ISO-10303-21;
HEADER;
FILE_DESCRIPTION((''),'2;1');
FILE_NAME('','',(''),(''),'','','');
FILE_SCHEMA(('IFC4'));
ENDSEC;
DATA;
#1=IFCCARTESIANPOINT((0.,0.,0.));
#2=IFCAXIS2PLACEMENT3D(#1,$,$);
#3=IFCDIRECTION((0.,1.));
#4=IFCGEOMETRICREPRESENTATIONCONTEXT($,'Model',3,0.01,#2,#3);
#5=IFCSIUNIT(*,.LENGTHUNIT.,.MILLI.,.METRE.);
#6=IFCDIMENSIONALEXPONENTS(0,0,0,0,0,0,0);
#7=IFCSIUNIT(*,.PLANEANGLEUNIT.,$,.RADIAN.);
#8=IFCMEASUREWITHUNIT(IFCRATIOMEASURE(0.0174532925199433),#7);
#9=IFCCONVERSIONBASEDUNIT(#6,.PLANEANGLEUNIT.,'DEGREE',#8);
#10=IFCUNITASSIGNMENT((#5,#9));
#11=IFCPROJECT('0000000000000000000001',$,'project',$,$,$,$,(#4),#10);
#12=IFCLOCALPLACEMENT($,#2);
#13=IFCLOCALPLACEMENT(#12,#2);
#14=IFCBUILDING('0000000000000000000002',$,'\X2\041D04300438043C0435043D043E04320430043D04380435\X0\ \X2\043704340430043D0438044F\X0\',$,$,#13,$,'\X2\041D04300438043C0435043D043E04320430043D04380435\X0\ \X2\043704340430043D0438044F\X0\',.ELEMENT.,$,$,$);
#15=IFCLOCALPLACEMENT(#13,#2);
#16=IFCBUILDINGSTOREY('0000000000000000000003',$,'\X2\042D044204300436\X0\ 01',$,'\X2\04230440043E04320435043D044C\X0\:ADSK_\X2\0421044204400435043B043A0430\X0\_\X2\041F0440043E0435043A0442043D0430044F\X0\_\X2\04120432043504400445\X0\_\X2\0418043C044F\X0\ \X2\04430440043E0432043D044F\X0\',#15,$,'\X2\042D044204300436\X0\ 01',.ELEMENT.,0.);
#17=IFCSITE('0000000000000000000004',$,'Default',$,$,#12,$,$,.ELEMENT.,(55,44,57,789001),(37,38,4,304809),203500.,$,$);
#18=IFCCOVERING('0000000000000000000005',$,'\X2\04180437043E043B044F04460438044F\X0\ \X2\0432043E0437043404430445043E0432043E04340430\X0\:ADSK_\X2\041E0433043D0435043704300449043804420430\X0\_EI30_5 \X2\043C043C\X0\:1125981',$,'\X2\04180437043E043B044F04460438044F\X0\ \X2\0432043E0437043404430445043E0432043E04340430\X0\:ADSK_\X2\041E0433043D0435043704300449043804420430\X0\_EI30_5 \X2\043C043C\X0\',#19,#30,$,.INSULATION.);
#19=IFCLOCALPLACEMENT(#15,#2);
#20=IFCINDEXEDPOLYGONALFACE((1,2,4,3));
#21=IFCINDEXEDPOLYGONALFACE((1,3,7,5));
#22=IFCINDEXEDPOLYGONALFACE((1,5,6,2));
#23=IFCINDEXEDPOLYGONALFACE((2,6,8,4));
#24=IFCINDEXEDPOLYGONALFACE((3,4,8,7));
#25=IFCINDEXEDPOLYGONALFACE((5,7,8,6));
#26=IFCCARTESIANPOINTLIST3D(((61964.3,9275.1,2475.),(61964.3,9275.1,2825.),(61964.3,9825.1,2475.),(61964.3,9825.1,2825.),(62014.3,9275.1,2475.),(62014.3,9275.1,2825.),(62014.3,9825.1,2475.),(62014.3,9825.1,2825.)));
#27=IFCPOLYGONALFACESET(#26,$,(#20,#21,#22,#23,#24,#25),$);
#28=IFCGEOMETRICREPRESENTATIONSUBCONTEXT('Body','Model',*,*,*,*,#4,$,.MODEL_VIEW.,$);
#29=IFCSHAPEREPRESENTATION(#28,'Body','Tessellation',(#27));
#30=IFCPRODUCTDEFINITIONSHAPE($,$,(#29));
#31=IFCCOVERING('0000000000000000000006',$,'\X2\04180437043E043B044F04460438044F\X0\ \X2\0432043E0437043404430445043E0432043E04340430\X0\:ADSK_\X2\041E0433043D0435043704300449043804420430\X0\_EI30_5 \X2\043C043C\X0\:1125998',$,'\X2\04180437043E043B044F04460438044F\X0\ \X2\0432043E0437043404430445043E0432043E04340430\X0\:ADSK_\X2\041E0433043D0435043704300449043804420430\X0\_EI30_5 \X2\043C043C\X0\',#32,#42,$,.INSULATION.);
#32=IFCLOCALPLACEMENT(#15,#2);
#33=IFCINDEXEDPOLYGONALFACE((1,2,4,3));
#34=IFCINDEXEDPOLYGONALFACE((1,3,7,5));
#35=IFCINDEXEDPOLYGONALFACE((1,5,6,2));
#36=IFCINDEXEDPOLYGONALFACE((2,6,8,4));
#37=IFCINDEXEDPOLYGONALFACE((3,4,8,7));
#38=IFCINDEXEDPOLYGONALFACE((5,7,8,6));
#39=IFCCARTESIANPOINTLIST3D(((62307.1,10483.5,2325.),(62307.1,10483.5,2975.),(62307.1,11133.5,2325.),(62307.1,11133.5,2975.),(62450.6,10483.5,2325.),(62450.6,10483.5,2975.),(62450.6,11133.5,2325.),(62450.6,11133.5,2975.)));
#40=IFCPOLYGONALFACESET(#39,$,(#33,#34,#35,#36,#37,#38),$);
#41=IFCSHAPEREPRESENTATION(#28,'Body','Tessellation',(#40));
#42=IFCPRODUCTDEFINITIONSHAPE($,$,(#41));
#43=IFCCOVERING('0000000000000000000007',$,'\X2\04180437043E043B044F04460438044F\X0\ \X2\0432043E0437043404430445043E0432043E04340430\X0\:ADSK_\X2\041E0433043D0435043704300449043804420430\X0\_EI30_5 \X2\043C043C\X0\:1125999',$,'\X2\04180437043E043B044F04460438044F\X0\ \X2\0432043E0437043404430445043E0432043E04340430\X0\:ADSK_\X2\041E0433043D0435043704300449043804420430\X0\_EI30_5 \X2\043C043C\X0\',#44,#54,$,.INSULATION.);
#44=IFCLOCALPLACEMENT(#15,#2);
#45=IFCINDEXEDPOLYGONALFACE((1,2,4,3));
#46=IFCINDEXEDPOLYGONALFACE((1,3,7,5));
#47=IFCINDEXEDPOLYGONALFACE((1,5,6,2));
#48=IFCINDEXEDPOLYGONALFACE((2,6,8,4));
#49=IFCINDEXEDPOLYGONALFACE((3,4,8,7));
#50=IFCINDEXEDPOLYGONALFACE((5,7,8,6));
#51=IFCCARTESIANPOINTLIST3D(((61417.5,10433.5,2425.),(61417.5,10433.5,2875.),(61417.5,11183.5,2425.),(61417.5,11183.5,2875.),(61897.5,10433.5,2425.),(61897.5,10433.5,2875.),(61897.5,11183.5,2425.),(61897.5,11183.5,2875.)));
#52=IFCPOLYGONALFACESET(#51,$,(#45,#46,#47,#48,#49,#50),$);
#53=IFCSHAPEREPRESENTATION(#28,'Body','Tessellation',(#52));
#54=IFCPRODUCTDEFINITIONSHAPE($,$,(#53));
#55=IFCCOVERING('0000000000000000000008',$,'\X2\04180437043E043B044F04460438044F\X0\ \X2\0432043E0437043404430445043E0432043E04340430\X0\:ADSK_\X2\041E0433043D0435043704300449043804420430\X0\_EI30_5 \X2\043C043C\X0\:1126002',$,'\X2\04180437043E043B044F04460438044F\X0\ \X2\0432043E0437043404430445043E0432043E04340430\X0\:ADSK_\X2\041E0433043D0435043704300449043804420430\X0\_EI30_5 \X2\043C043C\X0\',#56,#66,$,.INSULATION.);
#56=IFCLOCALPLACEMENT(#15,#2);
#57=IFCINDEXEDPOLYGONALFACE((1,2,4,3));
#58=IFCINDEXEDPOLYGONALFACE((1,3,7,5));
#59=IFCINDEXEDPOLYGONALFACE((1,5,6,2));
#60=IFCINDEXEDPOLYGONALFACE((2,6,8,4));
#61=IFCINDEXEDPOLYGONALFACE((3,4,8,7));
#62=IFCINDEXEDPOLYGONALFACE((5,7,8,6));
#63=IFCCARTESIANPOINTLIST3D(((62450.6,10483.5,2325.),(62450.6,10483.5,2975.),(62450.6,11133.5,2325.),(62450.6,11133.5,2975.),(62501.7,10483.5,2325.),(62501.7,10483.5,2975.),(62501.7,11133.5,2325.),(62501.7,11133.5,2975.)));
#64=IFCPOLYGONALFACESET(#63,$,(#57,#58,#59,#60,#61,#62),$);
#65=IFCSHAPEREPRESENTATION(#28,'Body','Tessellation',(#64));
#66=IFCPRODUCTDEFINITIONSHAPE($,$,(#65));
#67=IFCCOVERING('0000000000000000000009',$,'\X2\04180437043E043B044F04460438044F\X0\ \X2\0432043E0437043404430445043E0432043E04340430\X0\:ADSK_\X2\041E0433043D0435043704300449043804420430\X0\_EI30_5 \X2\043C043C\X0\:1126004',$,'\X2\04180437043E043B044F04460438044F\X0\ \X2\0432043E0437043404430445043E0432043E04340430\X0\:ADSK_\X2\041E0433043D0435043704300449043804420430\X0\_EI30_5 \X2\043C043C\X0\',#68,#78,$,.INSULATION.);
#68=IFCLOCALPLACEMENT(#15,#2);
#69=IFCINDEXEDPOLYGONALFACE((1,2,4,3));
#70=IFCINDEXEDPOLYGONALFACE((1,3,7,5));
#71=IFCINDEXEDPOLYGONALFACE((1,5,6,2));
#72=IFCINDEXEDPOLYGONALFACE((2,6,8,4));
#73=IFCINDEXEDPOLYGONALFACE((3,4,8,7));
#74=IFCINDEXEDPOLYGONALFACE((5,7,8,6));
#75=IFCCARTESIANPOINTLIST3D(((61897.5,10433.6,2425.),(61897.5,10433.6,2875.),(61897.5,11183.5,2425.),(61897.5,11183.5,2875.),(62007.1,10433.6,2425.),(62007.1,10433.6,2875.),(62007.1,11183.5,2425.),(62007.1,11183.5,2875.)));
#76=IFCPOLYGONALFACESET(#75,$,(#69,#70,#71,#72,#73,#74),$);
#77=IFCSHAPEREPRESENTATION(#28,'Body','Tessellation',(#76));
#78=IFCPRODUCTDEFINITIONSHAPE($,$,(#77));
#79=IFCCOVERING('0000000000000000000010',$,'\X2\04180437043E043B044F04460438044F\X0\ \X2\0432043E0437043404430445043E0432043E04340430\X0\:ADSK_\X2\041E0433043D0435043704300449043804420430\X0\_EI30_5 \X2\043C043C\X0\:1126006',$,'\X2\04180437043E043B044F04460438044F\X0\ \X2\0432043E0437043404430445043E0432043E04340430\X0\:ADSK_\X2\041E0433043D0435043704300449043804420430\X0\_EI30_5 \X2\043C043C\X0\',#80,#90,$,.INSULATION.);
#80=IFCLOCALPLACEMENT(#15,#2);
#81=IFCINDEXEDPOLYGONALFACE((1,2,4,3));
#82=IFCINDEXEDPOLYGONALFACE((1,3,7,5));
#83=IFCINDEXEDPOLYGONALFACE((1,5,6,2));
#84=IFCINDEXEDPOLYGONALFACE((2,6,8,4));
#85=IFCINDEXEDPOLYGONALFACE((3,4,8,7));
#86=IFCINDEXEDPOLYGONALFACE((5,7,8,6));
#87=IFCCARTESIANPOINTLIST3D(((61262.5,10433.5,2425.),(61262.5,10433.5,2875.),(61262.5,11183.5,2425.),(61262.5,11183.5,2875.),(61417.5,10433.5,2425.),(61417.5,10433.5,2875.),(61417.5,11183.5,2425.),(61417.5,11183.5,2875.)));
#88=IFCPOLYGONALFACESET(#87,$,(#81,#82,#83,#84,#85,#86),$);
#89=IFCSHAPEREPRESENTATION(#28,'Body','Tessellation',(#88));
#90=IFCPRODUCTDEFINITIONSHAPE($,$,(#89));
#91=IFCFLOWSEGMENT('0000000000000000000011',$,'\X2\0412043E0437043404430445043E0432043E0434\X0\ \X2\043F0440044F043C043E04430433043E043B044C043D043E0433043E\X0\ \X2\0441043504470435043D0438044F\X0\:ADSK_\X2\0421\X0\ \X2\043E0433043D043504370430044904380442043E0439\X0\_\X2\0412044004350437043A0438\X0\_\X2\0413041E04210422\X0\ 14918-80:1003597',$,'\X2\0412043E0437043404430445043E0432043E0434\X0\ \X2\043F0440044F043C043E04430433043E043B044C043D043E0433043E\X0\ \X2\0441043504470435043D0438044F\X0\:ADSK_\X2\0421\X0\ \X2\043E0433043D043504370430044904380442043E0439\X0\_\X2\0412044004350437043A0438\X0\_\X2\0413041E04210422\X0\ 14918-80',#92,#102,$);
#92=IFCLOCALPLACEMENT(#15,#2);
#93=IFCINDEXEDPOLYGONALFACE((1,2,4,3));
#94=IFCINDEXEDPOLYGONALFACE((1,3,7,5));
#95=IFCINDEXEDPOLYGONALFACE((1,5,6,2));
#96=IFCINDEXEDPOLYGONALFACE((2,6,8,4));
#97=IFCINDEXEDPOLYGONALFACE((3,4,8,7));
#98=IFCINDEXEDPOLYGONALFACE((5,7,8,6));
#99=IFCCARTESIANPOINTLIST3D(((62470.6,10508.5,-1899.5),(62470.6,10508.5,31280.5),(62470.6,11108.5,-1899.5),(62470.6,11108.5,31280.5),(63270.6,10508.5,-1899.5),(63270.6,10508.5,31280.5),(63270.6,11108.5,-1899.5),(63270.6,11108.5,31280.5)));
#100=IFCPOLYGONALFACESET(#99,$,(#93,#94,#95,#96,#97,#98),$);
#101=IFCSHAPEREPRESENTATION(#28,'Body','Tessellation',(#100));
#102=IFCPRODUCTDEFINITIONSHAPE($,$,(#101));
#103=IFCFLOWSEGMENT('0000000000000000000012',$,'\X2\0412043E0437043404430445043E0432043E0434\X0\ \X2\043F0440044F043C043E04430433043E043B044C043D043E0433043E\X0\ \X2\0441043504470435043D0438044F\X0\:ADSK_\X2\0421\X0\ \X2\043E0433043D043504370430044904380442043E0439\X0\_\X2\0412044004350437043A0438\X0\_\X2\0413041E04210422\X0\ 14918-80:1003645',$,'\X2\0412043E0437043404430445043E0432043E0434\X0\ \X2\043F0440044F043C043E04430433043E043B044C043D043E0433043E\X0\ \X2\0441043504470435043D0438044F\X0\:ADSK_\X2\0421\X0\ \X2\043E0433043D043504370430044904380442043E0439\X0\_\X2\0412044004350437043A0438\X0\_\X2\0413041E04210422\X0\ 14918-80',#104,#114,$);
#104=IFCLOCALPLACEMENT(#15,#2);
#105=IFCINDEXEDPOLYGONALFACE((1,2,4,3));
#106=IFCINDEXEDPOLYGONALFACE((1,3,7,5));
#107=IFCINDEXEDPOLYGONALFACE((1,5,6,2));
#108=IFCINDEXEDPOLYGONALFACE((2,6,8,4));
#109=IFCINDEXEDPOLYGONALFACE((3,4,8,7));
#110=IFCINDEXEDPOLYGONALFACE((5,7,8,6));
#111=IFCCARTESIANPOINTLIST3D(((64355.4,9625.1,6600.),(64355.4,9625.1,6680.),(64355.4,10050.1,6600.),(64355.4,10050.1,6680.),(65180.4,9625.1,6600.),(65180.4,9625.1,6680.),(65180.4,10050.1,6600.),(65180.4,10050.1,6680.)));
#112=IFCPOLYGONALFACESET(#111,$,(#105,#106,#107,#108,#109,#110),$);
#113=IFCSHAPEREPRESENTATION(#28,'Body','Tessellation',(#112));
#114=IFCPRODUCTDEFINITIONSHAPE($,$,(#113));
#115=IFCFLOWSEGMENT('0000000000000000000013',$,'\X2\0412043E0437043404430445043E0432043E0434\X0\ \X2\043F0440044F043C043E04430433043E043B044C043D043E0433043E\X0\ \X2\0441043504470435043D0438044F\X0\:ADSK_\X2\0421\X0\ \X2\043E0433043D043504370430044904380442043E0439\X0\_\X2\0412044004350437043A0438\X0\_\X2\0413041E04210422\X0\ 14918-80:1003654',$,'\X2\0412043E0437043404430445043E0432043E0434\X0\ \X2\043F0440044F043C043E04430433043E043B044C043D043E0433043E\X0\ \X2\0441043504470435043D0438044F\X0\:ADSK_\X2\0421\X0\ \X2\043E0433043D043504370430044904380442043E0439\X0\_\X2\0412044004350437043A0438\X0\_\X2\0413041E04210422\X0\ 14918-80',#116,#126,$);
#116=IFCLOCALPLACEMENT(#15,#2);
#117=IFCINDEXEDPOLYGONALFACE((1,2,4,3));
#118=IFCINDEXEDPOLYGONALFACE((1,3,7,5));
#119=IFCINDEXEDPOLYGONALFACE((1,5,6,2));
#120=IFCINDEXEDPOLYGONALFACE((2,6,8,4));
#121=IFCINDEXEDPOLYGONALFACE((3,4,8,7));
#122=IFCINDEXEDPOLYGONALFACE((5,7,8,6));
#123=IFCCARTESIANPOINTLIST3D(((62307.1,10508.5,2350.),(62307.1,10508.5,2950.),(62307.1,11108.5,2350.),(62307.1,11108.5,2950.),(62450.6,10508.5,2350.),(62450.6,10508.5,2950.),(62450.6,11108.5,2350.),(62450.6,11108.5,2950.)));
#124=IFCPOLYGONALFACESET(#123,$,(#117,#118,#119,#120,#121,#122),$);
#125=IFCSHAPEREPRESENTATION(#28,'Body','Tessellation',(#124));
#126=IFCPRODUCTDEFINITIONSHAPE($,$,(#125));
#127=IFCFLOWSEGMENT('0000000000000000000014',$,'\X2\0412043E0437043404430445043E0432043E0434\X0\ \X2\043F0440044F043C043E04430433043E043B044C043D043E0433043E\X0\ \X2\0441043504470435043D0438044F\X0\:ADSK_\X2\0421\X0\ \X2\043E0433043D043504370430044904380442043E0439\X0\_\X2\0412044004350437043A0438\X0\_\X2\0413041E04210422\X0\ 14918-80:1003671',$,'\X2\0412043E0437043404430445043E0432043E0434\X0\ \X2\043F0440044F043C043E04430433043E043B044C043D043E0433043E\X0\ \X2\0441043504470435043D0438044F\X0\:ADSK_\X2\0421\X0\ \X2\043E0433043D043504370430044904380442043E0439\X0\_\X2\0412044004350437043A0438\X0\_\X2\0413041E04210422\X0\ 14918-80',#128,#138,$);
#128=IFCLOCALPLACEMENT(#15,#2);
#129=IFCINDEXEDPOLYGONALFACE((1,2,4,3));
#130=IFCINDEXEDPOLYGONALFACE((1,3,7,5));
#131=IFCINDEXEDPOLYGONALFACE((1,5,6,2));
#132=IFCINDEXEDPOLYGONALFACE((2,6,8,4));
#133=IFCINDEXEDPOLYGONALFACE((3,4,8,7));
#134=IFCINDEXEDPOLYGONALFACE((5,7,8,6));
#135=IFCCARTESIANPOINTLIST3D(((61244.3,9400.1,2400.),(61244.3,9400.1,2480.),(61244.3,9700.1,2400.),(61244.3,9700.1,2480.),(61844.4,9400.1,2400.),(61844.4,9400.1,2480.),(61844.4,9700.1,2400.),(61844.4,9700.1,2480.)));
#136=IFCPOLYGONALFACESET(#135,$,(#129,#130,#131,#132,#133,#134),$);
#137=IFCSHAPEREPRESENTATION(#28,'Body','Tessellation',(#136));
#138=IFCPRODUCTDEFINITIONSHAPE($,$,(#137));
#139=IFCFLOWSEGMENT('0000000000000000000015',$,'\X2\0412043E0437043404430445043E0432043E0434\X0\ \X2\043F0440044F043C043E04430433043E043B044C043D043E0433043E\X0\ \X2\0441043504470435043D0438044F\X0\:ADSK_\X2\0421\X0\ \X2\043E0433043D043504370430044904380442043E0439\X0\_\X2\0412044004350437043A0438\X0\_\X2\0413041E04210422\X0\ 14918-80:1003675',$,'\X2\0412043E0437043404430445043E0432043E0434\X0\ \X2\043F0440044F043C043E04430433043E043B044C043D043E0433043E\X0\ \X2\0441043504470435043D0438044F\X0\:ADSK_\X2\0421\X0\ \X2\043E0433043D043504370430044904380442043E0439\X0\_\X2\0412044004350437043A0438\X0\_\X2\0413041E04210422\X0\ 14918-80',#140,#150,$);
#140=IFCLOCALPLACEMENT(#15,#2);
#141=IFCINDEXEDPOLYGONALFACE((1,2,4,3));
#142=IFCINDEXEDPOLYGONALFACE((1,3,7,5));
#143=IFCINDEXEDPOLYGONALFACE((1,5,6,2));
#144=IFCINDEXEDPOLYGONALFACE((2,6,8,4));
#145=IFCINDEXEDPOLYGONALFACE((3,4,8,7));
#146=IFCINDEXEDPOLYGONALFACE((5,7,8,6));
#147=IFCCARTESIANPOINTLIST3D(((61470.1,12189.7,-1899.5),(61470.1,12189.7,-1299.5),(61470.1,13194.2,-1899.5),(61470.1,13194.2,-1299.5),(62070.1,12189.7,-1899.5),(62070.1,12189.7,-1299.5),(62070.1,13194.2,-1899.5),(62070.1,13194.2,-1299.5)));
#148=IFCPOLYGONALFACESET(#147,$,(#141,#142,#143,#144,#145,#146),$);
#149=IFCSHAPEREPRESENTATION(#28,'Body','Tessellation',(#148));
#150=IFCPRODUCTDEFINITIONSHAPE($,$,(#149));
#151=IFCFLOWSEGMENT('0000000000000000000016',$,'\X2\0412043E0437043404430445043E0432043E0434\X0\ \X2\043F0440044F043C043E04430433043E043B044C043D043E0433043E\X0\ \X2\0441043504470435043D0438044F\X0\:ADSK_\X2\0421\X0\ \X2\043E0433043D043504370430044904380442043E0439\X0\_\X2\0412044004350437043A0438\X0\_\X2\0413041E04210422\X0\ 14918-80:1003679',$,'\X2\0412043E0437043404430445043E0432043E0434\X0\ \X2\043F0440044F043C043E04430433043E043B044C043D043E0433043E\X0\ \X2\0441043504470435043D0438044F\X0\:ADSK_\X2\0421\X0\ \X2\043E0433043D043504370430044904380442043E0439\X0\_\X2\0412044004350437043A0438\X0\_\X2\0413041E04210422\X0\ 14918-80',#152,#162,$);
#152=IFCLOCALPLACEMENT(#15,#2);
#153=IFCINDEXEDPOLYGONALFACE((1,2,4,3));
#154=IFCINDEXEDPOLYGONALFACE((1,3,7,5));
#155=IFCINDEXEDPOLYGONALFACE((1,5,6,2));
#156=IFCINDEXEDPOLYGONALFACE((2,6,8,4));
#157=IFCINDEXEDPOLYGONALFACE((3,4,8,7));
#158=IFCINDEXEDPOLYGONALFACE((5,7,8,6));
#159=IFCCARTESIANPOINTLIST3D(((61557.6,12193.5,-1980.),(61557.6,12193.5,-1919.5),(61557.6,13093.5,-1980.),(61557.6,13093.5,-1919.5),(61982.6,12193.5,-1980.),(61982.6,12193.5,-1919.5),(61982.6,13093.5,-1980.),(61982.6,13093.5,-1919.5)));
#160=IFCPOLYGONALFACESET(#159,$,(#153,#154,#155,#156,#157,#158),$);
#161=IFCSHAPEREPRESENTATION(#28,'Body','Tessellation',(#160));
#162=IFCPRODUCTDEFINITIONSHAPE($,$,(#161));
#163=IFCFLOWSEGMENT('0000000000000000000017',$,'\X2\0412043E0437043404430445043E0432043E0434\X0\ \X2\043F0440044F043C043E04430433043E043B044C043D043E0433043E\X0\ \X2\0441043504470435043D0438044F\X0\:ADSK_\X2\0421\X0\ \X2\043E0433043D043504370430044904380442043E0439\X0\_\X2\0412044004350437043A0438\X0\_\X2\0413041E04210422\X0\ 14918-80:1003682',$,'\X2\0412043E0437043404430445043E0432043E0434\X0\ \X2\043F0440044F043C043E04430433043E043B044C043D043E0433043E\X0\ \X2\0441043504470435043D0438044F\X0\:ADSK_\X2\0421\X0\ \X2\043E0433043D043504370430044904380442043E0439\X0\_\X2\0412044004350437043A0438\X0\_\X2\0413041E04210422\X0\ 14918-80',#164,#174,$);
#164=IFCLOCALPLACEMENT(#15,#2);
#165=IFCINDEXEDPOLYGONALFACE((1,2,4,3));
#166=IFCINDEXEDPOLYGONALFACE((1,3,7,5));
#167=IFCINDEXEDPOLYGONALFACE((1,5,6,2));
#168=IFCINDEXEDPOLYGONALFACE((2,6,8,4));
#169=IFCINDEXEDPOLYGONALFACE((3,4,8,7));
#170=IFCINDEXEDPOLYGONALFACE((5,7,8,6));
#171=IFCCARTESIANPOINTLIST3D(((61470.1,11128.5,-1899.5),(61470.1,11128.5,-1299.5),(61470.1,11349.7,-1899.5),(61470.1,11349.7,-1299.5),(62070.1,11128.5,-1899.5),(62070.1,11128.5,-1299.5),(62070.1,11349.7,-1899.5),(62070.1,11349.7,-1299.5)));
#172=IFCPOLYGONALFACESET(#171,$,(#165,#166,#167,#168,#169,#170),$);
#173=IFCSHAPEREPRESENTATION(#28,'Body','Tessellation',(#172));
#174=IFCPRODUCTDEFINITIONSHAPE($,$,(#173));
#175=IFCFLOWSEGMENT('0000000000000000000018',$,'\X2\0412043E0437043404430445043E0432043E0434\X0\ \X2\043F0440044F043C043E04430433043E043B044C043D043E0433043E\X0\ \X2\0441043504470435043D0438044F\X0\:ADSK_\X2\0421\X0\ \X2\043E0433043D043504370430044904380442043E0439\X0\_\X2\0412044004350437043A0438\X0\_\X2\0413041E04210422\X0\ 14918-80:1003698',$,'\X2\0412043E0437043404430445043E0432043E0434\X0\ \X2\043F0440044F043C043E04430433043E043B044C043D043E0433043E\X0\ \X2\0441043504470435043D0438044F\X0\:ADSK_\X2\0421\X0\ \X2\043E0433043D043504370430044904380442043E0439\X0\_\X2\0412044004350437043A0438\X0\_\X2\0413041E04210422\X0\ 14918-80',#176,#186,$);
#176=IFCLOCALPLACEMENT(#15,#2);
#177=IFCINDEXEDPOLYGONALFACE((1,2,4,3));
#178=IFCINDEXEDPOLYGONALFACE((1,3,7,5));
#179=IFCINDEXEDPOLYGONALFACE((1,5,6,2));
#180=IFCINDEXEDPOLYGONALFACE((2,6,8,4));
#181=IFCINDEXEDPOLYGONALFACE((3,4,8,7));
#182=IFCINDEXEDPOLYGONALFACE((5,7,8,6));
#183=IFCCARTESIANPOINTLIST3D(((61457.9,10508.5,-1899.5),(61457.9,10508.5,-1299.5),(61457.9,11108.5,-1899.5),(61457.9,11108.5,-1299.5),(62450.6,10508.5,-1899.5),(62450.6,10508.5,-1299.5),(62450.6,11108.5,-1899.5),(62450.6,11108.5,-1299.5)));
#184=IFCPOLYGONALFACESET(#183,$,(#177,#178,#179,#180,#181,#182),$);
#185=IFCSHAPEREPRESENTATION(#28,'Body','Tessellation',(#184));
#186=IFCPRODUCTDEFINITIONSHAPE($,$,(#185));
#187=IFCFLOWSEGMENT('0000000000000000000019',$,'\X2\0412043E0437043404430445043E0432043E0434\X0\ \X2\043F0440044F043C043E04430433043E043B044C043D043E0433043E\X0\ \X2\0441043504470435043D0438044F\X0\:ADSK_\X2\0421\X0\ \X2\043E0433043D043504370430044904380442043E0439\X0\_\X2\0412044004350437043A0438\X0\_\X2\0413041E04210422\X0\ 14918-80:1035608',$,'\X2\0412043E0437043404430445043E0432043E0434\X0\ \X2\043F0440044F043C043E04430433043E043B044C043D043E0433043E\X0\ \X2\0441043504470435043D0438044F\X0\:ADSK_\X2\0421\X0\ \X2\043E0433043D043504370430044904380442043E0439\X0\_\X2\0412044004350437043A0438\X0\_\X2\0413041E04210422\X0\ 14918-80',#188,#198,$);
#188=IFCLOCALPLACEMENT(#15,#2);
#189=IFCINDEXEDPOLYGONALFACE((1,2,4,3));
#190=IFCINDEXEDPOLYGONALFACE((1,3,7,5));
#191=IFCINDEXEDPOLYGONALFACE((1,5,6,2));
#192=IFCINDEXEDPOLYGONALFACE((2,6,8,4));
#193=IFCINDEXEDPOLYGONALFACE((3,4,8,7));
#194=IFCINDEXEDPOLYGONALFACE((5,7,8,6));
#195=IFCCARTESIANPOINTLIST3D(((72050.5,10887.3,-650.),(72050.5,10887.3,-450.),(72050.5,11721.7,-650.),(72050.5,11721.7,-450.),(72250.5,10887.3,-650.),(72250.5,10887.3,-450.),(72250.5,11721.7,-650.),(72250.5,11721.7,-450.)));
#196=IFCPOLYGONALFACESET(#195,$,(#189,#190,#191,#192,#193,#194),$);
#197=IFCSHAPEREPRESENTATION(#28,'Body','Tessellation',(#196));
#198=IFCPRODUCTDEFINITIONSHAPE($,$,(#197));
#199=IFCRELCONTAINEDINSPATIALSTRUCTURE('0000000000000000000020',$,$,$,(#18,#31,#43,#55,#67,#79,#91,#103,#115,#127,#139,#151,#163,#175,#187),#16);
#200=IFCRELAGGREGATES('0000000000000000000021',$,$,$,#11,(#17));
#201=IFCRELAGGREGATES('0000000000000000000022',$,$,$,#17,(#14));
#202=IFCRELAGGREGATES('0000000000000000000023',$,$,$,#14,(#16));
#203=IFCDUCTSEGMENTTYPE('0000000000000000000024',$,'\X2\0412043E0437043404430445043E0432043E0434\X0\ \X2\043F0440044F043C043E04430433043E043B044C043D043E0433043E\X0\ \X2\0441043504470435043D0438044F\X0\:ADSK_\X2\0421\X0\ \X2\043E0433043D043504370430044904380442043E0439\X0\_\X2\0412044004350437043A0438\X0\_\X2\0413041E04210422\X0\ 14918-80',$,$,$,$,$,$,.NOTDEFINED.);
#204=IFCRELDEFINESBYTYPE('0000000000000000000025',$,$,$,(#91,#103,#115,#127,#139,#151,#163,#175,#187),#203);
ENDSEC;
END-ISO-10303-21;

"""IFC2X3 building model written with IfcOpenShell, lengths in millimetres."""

from ifc_helpers import new_model, entity, si_unit, converted_unit, direction, frame, origin, origin_2d_with_axis, place, context, subcontext, project, spatial, rectangle, extrude, type_object, element, save


model = new_model("IFC2X3")

# Units and contexts
model_context = context("Model", 3, precision=0.01, world=origin(), true_north=direction((0.0, 1.0)))
body_context = subcontext(model_context, "Body", "Model", "MODEL_VIEW")
ifc_project = project(units=[si_unit("LENGTHUNIT", "METRE", prefix="MILLI"), converted_unit("PLANEANGLEUNIT", "DEGREE", entity("IfcRatioMeasure", 0.0174532925199433), si_unit("PLANEANGLEUNIT", "RADIAN"), dimensions=[0, 0, 0, 0, 0, 0, 0])], contexts=[model_context])

# Site, building, storey
site_placement = place(None, origin())
site = spatial("IfcSite", under=ifc_project, at=site_placement, Name="Default", CompositionType="ELEMENT", RefLatitude=(55, 44, 57, 789001), RefLongitude=(37, 38, 4, 304809), RefElevation=203500.0)
building_placement = place(site_placement, origin())
building = spatial("IfcBuilding", under=site, at=building_placement, Name="Наименование здания", LongName="Наименование здания", CompositionType="ELEMENT")
storey_placement = place(building_placement, origin())
storey = spatial("IfcBuildingStorey", under=building, at=storey_placement, Name="Этаж 01", ObjectType="Уровень:ADSK_Стрелка_Проектная_Вверх_Имя уровня", LongName="Этаж 01", CompositionType="ELEMENT", Elevation=0.0)

# Coverings
covering_1_placement = place(storey_placement, frame((61964.3, 9275.1, 2475.0)))
element("IfcCovering", 1, at=covering_1_placement, inside=storey, Name="Изоляция воздуховода:ADSK_Огнезащита_EI30_5 мм:1125981", ObjectType="Изоляция воздуховода:ADSK_Огнезащита_EI30_5 мм", PredefinedType="INSULATION", context=body_context, shape_type="SweptSolid", body=[
    extrude(rectangle(XDim=50.0, YDim=550.0, at=origin_2d_with_axis()), frame((25.0, 275.0, 0.0), z_axis=(0.0, 0.0, 1.0), x_axis=(-1.0, 0.000005, 0.0)), (0.0, 0.0, 1.0), 350.0),
])
covering_2_placement = place(storey_placement, frame((62307.1, 10483.5, 2325.0)))
element("IfcCovering", 2, at=covering_2_placement, inside=storey, Name="Изоляция воздуховода:ADSK_Огнезащита_EI30_5 мм:1125998", ObjectType="Изоляция воздуховода:ADSK_Огнезащита_EI30_5 мм", PredefinedType="INSULATION", context=body_context, shape_type="SweptSolid", body=[
    extrude(rectangle(XDim=143.5, YDim=650.0, at=origin_2d_with_axis()), frame((71.8, 325.0, 0.0), z_axis=(0.0, 0.0, 1.0), x_axis=(-1.0, 0.0, 0.0)), (0.0, 0.0, 1.0), 650.0),
])
covering_3_placement = place(storey_placement, frame((61417.5, 10433.5, 2425.0)))
element("IfcCovering", 3, at=covering_3_placement, inside=storey, Name="Изоляция воздуховода:ADSK_Огнезащита_EI30_5 мм:1125999", ObjectType="Изоляция воздуховода:ADSK_Огнезащита_EI30_5 мм", PredefinedType="INSULATION", context=body_context, shape_type="SweptSolid", body=[
    extrude(rectangle(XDim=480.0, YDim=750.0, at=origin_2d_with_axis()), frame((240.0, 375.0, 0.0), z_axis=(0.0, 0.0, 1.0), x_axis=(1.0, 0.000074, 0.0)), (0.0, 0.0, 1.0), 450.0),
])
covering_4_placement = place(storey_placement, frame((62450.6, 10483.5, 2325.0)))
element("IfcCovering", 4, at=covering_4_placement, inside=storey, Name="Изоляция воздуховода:ADSK_Огнезащита_EI30_5 мм:1126002", ObjectType="Изоляция воздуховода:ADSK_Огнезащита_EI30_5 мм", PredefinedType="INSULATION", context=body_context, shape_type="SweptSolid", body=[
    extrude(rectangle(XDim=650.0, YDim=51.1, at=origin_2d_with_axis()), frame((25.6, 325.0, 0.0), z_axis=(0.0, 0.0, 1.0), x_axis=(0.0, -1.0, 0.0)), (0.0, 0.0, 1.0), 650.0),
])
covering_5_placement = place(storey_placement, frame((61897.5, 10433.5, 2425.0)))
element("IfcCovering", 5, at=covering_5_placement, inside=storey, Name="Изоляция воздуховода:ADSK_Огнезащита_EI30_5 мм:1126004", ObjectType="Изоляция воздуховода:ADSK_Огнезащита_EI30_5 мм", PredefinedType="INSULATION", context=body_context, shape_type="SweptSolid", body=[
    extrude(rectangle(XDim=109.6, YDim=750.0, at=origin_2d_with_axis()), frame((54.8, 375.0, 0.0)), (0.0, 0.0, 1.0), 450.0),
])
covering_6_placement = place(storey_placement, frame((61262.5, 10433.5, 2425.0)))
element("IfcCovering", 6, at=covering_6_placement, inside=storey, Name="Изоляция воздуховода:ADSK_Огнезащита_EI30_5 мм:1126006", ObjectType="Изоляция воздуховода:ADSK_Огнезащита_EI30_5 мм", PredefinedType="INSULATION", context=body_context, shape_type="SweptSolid", body=[
    extrude(rectangle(XDim=155.0, YDim=750.0, at=origin_2d_with_axis()), frame((77.5, 375.0, 0.0), z_axis=(0.0, 0.0, 1.0), x_axis=(1.0, 0.000074, 0.0)), (0.0, 0.0, 1.0), 450.0),
])

# Flow segments
duct_segment_type = type_object("IfcDuctSegmentType", Name="Воздуховод прямоугольного сечения:ADSK_С огнезащитой_Врезки_ГОСТ 14918-80", PredefinedType="NOTDEFINED")
flow_segment_1_placement = place(storey_placement, frame((62470.6, 10508.5, -1899.5)))
element("IfcFlowSegment", 7, at=flow_segment_1_placement, inside=storey, type_object=duct_segment_type, Name="Воздуховод прямоугольного сечения:ADSK_С огнезащитой_Врезки_ГОСТ 14918-80:1003597", ObjectType="Воздуховод прямоугольного сечения:ADSK_С огнезащитой_Врезки_ГОСТ 14918-80", context=body_context, shape_type="SweptSolid", body=[
    extrude(rectangle(XDim=600.0, YDim=800.0, at=origin_2d_with_axis()), frame((400.0, 300.0, 0.0), z_axis=(0.0, 0.0, 1.0), x_axis=(0.0, 1.0, 0.0)), (0.0, 0.0, 1.0), 33180.0),
])
flow_segment_2_placement = place(storey_placement, frame((64355.4, 9625.1, 6600.0)))
element("IfcFlowSegment", 8, at=flow_segment_2_placement, inside=storey, type_object=duct_segment_type, Name="Воздуховод прямоугольного сечения:ADSK_С огнезащитой_Врезки_ГОСТ 14918-80:1003645", ObjectType="Воздуховод прямоугольного сечения:ADSK_С огнезащитой_Врезки_ГОСТ 14918-80", context=body_context, shape_type="SweptSolid", body=[
    extrude(rectangle(XDim=425.0, YDim=825.0, at=origin_2d_with_axis()), frame((412.5, 212.5, 0.0), z_axis=(0.0, 0.0, 1.0), x_axis=(0.0, -1.0, 0.0)), (0.0, 0.0, 1.0), 80.0),
])
flow_segment_3_placement = place(storey_placement, frame((62307.1, 10508.5, 2350.0)))
element("IfcFlowSegment", 9, at=flow_segment_3_placement, inside=storey, type_object=duct_segment_type, Name="Воздуховод прямоугольного сечения:ADSK_С огнезащитой_Врезки_ГОСТ 14918-80:1003654", ObjectType="Воздуховод прямоугольного сечения:ADSK_С огнезащитой_Врезки_ГОСТ 14918-80", context=body_context, shape_type="SweptSolid", body=[
    extrude(rectangle(XDim=143.5, YDim=600.0, at=origin_2d_with_axis()), frame((71.8, 300.0, 0.0), z_axis=(0.0, 0.0, 1.0), x_axis=(-1.0, 0.0, 0.0)), (0.0, 0.0, 1.0), 600.0),
])
flow_segment_4_placement = place(storey_placement, frame((61244.3, 9400.1, 2400.0)))
element("IfcFlowSegment", 10, at=flow_segment_4_placement, inside=storey, type_object=duct_segment_type, Name="Воздуховод прямоугольного сечения:ADSK_С огнезащитой_Врезки_ГОСТ 14918-80:1003671", ObjectType="Воздуховод прямоугольного сечения:ADSK_С огнезащитой_Врезки_ГОСТ 14918-80", context=body_context, shape_type="SweptSolid", body=[
    extrude(rectangle(XDim=600.0, YDim=300.0, at=origin_2d_with_axis()), frame((300.0, 150.0, 0.0)), (0.0, 0.0, 1.0), 80.0),
])
flow_segment_5_placement = place(storey_placement, frame((61470.1, 12189.7, -1899.5)))
element("IfcFlowSegment", 11, at=flow_segment_5_placement, inside=storey, type_object=duct_segment_type, Name="Воздуховод прямоугольного сечения:ADSK_С огнезащитой_Врезки_ГОСТ 14918-80:1003675", ObjectType="Воздуховод прямоугольного сечения:ADSK_С огнезащитой_Врезки_ГОСТ 14918-80", context=body_context, shape_type="SweptSolid", body=[
    extrude(rectangle(XDim=1004.4, YDim=600.0, at=origin_2d_with_axis()), frame((300.0, 502.2, 0.0), z_axis=(0.0, 0.0, 1.0), x_axis=(0.0, -1.0, 0.0)), (0.0, 0.0, 1.0), 600.0),
])
flow_segment_6_placement = place(storey_placement, frame((61557.6, 12193.5, -1980.0)))
element("IfcFlowSegment", 12, at=flow_segment_6_placement, inside=storey, type_object=duct_segment_type, Name="Воздуховод прямоугольного сечения:ADSK_С огнезащитой_Врезки_ГОСТ 14918-80:1003679", ObjectType="Воздуховод прямоугольного сечения:ADSK_С огнезащитой_Врезки_ГОСТ 14918-80", context=body_context, shape_type="SweptSolid", body=[
    extrude(rectangle(XDim=900.0, YDim=425.0, at=origin_2d_with_axis()), frame((212.5, 450.0, 0.0), z_axis=(0.0, 0.0, 1.0), x_axis=(0.000005, 1.0, 0.0)), (0.0, 0.0, 1.0), 60.5),
])
flow_segment_7_placement = place(storey_placement, frame((61470.1, 11128.5, -1899.5)))
element("IfcFlowSegment", 13, at=flow_segment_7_placement, inside=storey, type_object=duct_segment_type, Name="Воздуховод прямоугольного сечения:ADSK_С огнезащитой_Врезки_ГОСТ 14918-80:1003682", ObjectType="Воздуховод прямоугольного сечения:ADSK_С огнезащитой_Врезки_ГОСТ 14918-80", context=body_context, shape_type="SweptSolid", body=[
    extrude(rectangle(XDim=221.2, YDim=600.0, at=origin_2d_with_axis()), frame((300.0, 110.6, 0.0), z_axis=(0.0, 0.0, 1.0), x_axis=(0.0, 1.0, 0.0)), (0.0, 0.0, 1.0), 600.0),
])
flow_segment_8_placement = place(storey_placement, frame((61457.9, 10508.5, -1899.5)))
element("IfcFlowSegment", 14, at=flow_segment_8_placement, inside=storey, type_object=duct_segment_type, Name="Воздуховод прямоугольного сечения:ADSK_С огнезащитой_Врезки_ГОСТ 14918-80:1003698", ObjectType="Воздуховод прямоугольного сечения:ADSK_С огнезащитой_Врезки_ГОСТ 14918-80", context=body_context, shape_type="SweptSolid", body=[
    extrude(rectangle(XDim=992.7, YDim=600.0, at=origin_2d_with_axis()), frame((496.4, 300.0, 0.0), z_axis=(0.0, 0.0, 1.0), x_axis=(-1.0, 0.0, 0.0)), (0.0, 0.0, 1.0), 600.0),
])
flow_segment_9_placement = place(storey_placement, frame((72050.5, 10887.3, -650.0)))
element("IfcFlowSegment", 15, at=flow_segment_9_placement, inside=storey, type_object=duct_segment_type, Name="Воздуховод прямоугольного сечения:ADSK_С огнезащитой_Врезки_ГОСТ 14918-80:1035608", ObjectType="Воздуховод прямоугольного сечения:ADSK_С огнезащитой_Врезки_ГОСТ 14918-80", context=body_context, shape_type="SweptSolid", body=[
    extrude(rectangle(XDim=834.4, YDim=200.0, at=origin_2d_with_axis()), frame((100.0, 417.2, 0.0), z_axis=(0.0, 0.0, 1.0), x_axis=(0.0, 1.0, 0.0)), (0.0, 0.0, 1.0), 200.0),
])

save(model, "model.ifc")
